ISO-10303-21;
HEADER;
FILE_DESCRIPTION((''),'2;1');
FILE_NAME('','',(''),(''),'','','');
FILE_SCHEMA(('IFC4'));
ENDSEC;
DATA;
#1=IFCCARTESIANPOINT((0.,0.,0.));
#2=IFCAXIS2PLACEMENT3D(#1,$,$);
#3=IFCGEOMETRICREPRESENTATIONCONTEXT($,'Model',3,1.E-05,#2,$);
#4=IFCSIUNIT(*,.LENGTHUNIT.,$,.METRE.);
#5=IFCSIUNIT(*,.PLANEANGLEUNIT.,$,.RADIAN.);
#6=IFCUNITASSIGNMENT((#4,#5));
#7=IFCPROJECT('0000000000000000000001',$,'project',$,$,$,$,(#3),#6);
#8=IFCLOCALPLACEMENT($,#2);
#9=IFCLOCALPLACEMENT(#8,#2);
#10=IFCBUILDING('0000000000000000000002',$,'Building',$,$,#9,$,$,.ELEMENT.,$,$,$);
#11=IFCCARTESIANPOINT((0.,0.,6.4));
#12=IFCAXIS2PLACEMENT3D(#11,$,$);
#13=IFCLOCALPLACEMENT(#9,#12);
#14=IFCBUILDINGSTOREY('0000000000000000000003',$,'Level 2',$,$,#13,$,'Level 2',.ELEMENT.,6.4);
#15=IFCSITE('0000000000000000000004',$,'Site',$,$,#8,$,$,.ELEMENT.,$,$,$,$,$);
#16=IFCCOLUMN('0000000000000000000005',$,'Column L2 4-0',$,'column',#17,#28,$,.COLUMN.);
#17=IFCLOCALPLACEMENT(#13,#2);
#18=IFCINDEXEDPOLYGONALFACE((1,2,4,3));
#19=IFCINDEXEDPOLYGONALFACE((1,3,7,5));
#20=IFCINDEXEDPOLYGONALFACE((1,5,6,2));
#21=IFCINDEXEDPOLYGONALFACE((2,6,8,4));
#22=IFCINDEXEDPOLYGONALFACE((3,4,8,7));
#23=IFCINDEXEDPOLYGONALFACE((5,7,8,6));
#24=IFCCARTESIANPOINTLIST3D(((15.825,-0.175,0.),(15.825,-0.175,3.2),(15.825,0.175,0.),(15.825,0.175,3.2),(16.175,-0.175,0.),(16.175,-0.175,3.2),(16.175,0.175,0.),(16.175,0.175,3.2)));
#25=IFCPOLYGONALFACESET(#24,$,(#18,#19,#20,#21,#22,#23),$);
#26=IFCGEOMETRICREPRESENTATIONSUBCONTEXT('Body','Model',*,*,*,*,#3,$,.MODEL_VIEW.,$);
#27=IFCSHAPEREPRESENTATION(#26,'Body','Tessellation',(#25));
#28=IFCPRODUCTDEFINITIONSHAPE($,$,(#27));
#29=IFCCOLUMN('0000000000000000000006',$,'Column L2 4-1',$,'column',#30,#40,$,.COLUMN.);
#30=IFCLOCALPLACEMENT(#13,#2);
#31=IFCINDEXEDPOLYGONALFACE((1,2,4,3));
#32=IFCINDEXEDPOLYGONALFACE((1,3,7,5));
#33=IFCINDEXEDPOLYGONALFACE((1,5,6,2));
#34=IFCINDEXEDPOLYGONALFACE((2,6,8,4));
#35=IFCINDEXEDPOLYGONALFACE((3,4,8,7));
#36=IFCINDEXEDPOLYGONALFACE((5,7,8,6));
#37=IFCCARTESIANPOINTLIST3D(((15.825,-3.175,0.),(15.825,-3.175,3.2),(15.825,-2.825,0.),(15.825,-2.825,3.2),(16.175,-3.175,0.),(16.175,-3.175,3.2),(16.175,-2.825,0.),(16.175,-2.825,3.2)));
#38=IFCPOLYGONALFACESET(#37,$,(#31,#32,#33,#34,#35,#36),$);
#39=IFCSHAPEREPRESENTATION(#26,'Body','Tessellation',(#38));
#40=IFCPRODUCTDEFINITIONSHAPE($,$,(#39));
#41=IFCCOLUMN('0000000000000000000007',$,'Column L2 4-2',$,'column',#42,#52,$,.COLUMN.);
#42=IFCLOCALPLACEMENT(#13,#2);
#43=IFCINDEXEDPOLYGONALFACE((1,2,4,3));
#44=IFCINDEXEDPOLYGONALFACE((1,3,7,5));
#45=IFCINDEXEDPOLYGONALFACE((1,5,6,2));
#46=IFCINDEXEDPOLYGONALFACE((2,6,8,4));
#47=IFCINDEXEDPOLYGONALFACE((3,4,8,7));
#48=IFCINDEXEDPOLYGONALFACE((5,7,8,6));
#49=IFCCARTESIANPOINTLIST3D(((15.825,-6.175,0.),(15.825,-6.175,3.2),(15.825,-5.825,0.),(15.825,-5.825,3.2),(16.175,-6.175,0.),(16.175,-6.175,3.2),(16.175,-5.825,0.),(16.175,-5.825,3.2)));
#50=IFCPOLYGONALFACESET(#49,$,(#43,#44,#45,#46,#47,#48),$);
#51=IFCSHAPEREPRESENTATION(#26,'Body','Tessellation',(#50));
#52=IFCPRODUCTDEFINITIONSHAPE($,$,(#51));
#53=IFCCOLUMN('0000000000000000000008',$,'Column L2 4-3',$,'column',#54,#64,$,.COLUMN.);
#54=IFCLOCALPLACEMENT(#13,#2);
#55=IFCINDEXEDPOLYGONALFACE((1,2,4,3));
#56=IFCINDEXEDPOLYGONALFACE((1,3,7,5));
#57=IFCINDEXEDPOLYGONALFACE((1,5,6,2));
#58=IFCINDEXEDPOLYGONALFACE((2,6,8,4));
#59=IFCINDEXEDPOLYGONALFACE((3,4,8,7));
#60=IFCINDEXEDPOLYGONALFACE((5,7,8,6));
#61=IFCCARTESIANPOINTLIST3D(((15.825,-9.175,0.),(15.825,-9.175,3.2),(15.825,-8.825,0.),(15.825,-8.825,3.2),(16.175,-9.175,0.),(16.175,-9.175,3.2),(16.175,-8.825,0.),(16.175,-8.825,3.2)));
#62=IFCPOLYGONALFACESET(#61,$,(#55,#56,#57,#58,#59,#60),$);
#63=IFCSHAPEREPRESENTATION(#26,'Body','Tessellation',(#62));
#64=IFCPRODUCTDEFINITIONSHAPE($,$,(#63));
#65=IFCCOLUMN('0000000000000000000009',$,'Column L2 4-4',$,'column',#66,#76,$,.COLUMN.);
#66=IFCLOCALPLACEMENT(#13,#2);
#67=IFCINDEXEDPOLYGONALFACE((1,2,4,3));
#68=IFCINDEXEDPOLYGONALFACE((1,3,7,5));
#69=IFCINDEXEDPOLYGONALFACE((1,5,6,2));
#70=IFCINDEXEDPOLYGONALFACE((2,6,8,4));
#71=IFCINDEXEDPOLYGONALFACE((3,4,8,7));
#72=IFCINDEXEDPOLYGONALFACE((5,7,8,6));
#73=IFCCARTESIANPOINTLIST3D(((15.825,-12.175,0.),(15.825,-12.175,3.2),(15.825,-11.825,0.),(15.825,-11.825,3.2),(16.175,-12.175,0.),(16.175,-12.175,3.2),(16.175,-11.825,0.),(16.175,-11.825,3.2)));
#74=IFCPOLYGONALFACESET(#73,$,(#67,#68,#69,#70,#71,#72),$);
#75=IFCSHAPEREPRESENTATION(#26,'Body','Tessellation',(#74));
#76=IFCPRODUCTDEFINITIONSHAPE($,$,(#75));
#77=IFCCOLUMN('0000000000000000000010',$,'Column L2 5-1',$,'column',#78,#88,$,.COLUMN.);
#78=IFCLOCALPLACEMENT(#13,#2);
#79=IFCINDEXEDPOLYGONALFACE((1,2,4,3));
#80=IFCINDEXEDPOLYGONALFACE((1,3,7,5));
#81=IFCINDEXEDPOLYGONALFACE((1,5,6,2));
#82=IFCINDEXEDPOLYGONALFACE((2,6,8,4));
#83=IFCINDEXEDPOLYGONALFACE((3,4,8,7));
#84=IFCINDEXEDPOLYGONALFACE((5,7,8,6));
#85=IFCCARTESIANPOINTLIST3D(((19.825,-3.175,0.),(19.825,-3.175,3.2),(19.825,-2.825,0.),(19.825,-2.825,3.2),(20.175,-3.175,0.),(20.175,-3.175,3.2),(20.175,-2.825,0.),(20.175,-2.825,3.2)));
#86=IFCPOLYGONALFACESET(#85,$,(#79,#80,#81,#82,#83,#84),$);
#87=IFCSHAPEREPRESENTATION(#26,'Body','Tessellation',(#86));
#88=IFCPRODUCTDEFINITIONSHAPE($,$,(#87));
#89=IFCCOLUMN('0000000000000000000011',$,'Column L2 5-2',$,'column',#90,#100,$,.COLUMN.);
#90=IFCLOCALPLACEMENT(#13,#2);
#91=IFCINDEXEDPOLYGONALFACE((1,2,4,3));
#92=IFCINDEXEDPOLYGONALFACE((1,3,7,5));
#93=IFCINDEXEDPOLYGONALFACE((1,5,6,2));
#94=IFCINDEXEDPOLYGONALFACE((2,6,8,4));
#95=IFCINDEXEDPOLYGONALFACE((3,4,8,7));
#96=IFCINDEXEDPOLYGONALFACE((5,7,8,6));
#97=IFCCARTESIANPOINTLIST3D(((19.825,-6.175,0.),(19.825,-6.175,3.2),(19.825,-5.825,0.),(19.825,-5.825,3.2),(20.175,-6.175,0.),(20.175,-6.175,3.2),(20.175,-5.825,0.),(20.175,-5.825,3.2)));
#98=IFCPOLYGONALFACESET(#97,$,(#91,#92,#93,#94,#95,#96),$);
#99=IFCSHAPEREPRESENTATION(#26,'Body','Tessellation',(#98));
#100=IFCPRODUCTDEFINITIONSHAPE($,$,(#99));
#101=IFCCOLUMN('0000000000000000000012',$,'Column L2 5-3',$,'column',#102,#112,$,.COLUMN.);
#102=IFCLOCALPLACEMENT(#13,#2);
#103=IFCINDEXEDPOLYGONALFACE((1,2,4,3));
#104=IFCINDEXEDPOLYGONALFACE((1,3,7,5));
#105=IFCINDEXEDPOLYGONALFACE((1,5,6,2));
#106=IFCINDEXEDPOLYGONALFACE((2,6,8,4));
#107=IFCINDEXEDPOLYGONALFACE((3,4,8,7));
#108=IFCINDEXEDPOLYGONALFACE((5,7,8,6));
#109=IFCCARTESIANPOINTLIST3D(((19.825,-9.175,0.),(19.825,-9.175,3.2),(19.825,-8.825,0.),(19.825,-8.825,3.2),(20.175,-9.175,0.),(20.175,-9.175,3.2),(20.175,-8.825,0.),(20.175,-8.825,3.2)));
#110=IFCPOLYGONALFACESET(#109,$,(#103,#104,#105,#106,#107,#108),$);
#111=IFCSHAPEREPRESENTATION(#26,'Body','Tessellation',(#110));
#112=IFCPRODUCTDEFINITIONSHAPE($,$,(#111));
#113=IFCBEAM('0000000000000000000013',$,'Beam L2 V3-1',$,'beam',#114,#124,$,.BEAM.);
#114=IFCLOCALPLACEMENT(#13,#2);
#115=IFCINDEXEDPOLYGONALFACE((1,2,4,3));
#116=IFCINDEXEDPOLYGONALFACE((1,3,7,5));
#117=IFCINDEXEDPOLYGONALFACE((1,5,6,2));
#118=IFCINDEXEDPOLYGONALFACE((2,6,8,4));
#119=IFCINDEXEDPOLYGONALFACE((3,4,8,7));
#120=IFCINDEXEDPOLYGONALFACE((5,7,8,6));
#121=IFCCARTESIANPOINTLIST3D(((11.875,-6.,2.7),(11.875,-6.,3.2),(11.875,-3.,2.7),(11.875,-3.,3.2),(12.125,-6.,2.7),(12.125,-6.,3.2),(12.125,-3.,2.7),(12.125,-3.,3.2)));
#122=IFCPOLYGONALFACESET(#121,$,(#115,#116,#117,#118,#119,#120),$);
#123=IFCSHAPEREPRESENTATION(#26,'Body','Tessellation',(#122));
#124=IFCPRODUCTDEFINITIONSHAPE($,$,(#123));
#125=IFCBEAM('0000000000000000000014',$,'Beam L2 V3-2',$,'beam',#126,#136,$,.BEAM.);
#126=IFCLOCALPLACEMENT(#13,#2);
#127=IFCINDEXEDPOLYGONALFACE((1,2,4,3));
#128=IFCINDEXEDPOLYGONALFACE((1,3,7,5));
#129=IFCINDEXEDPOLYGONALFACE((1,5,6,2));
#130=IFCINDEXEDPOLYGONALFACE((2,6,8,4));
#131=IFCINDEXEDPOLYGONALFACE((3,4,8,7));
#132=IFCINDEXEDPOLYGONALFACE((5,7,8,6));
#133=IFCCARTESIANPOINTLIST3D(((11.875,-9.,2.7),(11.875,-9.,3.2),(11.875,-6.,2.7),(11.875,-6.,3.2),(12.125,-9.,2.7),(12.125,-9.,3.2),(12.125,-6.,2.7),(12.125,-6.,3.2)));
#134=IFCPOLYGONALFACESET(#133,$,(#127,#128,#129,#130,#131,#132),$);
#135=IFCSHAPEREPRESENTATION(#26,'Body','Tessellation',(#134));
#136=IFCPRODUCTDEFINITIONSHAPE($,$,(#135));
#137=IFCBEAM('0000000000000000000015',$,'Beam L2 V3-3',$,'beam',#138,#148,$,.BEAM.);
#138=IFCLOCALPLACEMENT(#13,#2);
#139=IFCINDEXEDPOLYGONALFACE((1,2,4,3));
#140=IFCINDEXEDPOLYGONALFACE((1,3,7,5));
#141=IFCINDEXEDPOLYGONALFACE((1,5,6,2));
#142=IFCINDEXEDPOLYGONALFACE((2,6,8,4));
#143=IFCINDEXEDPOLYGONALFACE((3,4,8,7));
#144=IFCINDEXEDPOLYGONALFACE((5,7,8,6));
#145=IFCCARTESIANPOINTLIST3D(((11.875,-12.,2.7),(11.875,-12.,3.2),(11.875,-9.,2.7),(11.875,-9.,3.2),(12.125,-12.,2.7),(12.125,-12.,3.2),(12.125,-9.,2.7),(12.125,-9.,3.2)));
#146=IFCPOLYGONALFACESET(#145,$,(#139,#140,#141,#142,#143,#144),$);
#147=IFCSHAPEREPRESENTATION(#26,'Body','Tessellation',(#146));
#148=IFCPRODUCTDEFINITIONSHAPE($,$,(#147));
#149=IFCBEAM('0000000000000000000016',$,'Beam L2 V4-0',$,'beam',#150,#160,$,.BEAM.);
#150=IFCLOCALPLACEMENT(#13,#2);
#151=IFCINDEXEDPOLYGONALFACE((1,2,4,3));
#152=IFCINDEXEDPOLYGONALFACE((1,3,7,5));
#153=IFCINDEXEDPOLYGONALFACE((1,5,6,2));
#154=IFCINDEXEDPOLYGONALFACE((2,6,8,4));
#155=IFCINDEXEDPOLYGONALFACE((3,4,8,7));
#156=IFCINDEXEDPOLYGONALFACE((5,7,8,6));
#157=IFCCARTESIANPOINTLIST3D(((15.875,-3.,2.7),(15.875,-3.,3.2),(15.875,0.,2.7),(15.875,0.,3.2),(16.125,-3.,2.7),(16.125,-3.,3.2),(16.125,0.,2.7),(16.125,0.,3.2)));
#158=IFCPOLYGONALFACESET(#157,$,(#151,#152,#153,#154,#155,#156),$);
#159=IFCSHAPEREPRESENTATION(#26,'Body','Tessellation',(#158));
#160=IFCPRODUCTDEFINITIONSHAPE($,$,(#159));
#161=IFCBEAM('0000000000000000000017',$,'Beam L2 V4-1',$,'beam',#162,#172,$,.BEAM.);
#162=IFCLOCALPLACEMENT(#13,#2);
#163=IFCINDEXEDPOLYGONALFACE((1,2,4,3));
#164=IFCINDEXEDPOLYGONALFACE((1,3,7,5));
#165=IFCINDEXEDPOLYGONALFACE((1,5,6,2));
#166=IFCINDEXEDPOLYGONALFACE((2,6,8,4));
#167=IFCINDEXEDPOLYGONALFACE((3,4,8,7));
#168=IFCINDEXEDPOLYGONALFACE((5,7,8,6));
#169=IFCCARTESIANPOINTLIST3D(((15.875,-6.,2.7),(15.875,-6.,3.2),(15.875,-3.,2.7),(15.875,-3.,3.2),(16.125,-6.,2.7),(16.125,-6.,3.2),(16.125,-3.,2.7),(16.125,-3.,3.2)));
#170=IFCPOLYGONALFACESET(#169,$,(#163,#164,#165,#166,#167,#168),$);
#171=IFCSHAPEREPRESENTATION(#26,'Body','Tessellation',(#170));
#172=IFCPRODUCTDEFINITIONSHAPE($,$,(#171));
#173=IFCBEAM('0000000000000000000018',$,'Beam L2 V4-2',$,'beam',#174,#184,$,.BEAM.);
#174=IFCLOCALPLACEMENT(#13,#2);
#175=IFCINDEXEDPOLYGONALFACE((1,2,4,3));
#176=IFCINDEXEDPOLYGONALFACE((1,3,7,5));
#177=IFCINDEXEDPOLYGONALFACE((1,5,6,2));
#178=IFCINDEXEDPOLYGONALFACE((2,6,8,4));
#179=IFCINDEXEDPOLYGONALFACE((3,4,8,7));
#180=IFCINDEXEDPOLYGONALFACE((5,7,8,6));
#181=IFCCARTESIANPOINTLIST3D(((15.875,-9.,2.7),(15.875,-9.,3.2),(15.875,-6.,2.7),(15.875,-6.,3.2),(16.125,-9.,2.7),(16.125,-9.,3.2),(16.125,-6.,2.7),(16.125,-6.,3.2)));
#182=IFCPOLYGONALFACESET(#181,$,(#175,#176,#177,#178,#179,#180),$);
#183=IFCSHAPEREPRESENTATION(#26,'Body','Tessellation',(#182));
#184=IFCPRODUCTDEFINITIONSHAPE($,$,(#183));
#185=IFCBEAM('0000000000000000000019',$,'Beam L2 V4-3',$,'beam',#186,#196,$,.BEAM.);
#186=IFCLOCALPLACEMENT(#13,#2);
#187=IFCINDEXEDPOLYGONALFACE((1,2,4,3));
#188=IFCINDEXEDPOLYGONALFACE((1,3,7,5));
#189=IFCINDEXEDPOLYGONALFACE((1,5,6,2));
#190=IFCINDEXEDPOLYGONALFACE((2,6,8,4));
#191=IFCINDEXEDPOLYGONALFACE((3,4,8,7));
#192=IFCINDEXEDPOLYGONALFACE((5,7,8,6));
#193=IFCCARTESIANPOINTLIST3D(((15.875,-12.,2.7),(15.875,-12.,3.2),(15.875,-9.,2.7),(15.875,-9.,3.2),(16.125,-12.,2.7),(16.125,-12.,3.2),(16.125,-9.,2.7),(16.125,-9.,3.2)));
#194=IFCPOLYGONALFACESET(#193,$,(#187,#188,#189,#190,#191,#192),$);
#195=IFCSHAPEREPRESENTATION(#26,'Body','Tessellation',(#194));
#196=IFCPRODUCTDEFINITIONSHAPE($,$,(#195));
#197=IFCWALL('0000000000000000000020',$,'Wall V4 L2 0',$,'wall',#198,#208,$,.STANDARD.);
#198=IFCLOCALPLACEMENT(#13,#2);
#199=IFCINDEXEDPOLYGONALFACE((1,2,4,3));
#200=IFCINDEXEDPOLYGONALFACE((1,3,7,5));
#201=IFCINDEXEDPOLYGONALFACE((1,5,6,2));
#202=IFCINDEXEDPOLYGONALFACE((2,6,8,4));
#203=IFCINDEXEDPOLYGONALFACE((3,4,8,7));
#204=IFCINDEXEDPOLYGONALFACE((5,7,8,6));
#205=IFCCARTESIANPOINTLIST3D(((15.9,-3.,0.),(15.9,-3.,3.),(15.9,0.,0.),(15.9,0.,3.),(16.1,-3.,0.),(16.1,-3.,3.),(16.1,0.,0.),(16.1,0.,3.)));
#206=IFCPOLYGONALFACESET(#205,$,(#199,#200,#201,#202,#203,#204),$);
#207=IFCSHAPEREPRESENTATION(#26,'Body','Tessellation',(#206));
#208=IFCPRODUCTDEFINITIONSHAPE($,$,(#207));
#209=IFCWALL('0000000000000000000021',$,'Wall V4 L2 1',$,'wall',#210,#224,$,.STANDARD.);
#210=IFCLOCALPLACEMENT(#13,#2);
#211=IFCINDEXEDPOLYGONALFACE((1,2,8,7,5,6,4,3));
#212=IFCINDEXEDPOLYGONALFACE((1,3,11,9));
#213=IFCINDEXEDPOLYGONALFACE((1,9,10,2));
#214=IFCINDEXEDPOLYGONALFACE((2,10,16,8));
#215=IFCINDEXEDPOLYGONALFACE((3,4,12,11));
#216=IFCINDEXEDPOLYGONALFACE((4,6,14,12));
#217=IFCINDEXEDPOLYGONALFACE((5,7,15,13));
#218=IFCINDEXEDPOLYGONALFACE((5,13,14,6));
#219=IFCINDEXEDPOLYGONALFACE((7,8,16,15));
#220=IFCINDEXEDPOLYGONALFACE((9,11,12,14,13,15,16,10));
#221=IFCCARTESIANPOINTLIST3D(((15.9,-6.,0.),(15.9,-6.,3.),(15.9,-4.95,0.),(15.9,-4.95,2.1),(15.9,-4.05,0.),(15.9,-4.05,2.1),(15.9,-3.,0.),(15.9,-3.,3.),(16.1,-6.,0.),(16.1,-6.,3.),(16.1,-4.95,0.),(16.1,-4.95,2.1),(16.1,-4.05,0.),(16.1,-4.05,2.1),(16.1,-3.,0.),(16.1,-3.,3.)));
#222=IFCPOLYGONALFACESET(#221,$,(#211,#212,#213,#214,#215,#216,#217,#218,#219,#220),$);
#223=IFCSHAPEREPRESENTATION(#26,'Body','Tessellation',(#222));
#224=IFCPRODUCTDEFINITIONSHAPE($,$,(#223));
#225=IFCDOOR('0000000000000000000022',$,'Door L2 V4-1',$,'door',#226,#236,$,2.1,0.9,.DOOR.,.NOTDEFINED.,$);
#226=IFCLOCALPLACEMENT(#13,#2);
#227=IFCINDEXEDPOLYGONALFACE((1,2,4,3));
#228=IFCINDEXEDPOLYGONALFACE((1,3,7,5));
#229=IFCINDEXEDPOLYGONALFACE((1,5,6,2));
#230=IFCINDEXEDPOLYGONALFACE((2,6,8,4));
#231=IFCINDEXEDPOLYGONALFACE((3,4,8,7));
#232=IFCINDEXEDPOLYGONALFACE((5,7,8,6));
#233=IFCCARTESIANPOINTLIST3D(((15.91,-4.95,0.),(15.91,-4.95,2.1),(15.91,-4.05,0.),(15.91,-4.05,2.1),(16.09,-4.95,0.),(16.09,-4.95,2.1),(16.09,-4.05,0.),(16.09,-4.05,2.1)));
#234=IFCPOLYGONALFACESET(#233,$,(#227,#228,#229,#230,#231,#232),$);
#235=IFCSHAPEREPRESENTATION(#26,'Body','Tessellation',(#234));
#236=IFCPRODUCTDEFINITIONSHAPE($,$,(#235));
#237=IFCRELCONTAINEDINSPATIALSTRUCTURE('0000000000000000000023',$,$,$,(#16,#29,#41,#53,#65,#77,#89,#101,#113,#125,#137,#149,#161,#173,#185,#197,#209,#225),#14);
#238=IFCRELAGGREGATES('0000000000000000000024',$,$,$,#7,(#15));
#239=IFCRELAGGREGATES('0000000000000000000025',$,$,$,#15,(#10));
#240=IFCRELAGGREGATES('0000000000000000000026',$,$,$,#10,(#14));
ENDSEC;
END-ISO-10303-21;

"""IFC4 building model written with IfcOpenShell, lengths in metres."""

from ifc_helpers import new_model, si_unit, frame, frame_2d, origin, origin_2d, place, context, subcontext, project, spatial, rectangle, extrude, element, fill, save


model = new_model("IFC4")

# Units and contexts
model_context = context("Model", 3, precision=1e-05, world=origin())
body_context = subcontext(model_context, "Body", "Model", "MODEL_VIEW")
ifc_project = project(units=[si_unit("LENGTHUNIT", "METRE"), si_unit("PLANEANGLEUNIT", "RADIAN")], contexts=[model_context])

# Site, building, storey
site_placement = place(None, origin())
site = spatial("IfcSite", under=ifc_project, at=site_placement, Name="Site", CompositionType="ELEMENT")
building_placement = place(site_placement, origin())
building = spatial("IfcBuilding", under=site, at=building_placement, Name="Building", CompositionType="ELEMENT")
storey_placement = place(building_placement, frame((0.0, 0.0, 6.4)))
storey = spatial("IfcBuildingStorey", under=building, at=storey_placement, Name="Level 2", LongName="Level 2", CompositionType="ELEMENT", Elevation=6.4)

# Columns
for number, where, name in (
    (1, (16.0, 0.0, 0.0), "Column L2 4-0"),
    (2, (16.0, -3.0, 0.0), "Column L2 4-1"),
    (3, (16.0, -6.0, 0.0), "Column L2 4-2"),
    (4, (16.0, -9.0, 0.0), "Column L2 4-3"),
    (5, (16.0, -12.0, 0.0), "Column L2 4-4"),
    (6, (20.0, -3.0, 0.0), "Column L2 5-1"),
    (7, (20.0, -6.0, 0.0), "Column L2 5-2"),
    (8, (20.0, -9.0, 0.0), "Column L2 5-3"),
):
    element("IfcColumn", number, at=place(storey_placement, frame(where)), inside=storey, Name=name, ObjectType="column", PredefinedType="COLUMN", context=body_context, shape_type="SweptSolid", body=[
        extrude(rectangle(XDim=0.35, YDim=0.35, at=origin_2d()), origin(), (0.0, 0.0, 1.0), 3.2),
    ])

# Beams
for number, where, z_axis, x_axis, name in (
    (9, (12.0, -3.0, 2.95), (0.0, -1.0, 0.0), (0.0, 0.0, 1.0), "Beam L2 V3-1"),
    (10, (12.0, -6.0, 2.95), (0.0, -1.0, 0.0), (0.0, 0.0, 1.0), "Beam L2 V3-2"),
    (11, (12.0, -9.0, 2.95), (0.0, -1.0, 0.0), (0.0, 0.0, 1.0), "Beam L2 V3-3"),
    (12, (16.0, 0.0, 2.95), (0.0, -1.0, 0.0), (0.0, 0.0, 1.0), "Beam L2 V4-0"),
    (13, (16.0, -3.0, 2.95), (0.0, -1.0, 0.0), (0.0, 0.0, 1.0), "Beam L2 V4-1"),
    (14, (16.0, -6.0, 2.95), (0.0, -1.0, 0.0), (0.0, 0.0, 1.0), "Beam L2 V4-2"),
    (15, (16.0, -9.0, 2.95), (0.0, -1.0, 0.0), (0.0, 0.0, 1.0), "Beam L2 V4-3"),
):
    element("IfcBeam", number, at=place(storey_placement, frame(where, z_axis=z_axis, x_axis=x_axis)), inside=storey, Name=name, ObjectType="beam", PredefinedType="BEAM", context=body_context, shape_type="SweptSolid", body=[
        extrude(rectangle(XDim=0.5, YDim=0.25, at=origin_2d()), origin(), (0.0, 0.0, 1.0), 3.0),
    ])

# Wall
wall_1_placement = place(storey_placement, frame((16.0, 0.0, 0.0), z_axis=(0.0, 0.0, 1.0), x_axis=(0.0, -1.0, 0.0)))
element("IfcWall", 16, at=wall_1_placement, inside=storey, Name="Wall V4 L2 0", ObjectType="wall", PredefinedType="STANDARD", context=body_context, shape_type="SweptSolid", body=[
    extrude(rectangle(XDim=3.0, YDim=0.2, at=frame_2d((1.5, 0.0))), origin(), (0.0, 0.0, 1.0), 3.0),
])

# Wall, opening, door
wall_2_placement = place(storey_placement, frame((16.0, -3.0, 0.0), z_axis=(0.0, 0.0, 1.0), x_axis=(0.0, -1.0, 0.0)))
wall_2 = element("IfcWall", 17, at=wall_2_placement, inside=storey, Name="Wall V4 L2 1", ObjectType="wall", PredefinedType="STANDARD", context=body_context, shape_type="SweptSolid", body=[
    extrude(rectangle(XDim=3.0, YDim=0.2, at=frame_2d((1.5, 0.0))), origin(), (0.0, 0.0, 1.0), 3.0),
])
opening_1_placement = place(storey_placement, frame((16.0, -4.5, 0.0), z_axis=(0.0, 0.0, 1.0), x_axis=(0.0, -1.0, 0.0)))
opening_1 = element("IfcOpeningElement", 18, at=opening_1_placement, cuts=wall_2, ObjectType="Opening", PredefinedType="OPENING", context=body_context, shape_type="SweptSolid", body=[
    extrude(rectangle(XDim=0.9, YDim=0.22, at=origin_2d()), origin(), (0.0, 0.0, 1.0), 2.1),
])
door_placement = place(storey_placement, frame((16.0, -4.5, 0.0), z_axis=(0.0, 0.0, 1.0), x_axis=(0.0, -1.0, 0.0)))
door = element("IfcDoor", 19, at=door_placement, inside=storey, Name="Door L2 V4-1", ObjectType="door", OperationType="NOTDEFINED", OverallHeight=2.1, OverallWidth=0.9, PredefinedType="DOOR", context=body_context, shape_type="SweptSolid", body=[
    extrude(rectangle(XDim=0.9, YDim=0.18, at=origin_2d()), origin(), (0.0, 0.0, 1.0), 2.1),
])
fill(opening_1, door)

save(model, "model.ifc")
